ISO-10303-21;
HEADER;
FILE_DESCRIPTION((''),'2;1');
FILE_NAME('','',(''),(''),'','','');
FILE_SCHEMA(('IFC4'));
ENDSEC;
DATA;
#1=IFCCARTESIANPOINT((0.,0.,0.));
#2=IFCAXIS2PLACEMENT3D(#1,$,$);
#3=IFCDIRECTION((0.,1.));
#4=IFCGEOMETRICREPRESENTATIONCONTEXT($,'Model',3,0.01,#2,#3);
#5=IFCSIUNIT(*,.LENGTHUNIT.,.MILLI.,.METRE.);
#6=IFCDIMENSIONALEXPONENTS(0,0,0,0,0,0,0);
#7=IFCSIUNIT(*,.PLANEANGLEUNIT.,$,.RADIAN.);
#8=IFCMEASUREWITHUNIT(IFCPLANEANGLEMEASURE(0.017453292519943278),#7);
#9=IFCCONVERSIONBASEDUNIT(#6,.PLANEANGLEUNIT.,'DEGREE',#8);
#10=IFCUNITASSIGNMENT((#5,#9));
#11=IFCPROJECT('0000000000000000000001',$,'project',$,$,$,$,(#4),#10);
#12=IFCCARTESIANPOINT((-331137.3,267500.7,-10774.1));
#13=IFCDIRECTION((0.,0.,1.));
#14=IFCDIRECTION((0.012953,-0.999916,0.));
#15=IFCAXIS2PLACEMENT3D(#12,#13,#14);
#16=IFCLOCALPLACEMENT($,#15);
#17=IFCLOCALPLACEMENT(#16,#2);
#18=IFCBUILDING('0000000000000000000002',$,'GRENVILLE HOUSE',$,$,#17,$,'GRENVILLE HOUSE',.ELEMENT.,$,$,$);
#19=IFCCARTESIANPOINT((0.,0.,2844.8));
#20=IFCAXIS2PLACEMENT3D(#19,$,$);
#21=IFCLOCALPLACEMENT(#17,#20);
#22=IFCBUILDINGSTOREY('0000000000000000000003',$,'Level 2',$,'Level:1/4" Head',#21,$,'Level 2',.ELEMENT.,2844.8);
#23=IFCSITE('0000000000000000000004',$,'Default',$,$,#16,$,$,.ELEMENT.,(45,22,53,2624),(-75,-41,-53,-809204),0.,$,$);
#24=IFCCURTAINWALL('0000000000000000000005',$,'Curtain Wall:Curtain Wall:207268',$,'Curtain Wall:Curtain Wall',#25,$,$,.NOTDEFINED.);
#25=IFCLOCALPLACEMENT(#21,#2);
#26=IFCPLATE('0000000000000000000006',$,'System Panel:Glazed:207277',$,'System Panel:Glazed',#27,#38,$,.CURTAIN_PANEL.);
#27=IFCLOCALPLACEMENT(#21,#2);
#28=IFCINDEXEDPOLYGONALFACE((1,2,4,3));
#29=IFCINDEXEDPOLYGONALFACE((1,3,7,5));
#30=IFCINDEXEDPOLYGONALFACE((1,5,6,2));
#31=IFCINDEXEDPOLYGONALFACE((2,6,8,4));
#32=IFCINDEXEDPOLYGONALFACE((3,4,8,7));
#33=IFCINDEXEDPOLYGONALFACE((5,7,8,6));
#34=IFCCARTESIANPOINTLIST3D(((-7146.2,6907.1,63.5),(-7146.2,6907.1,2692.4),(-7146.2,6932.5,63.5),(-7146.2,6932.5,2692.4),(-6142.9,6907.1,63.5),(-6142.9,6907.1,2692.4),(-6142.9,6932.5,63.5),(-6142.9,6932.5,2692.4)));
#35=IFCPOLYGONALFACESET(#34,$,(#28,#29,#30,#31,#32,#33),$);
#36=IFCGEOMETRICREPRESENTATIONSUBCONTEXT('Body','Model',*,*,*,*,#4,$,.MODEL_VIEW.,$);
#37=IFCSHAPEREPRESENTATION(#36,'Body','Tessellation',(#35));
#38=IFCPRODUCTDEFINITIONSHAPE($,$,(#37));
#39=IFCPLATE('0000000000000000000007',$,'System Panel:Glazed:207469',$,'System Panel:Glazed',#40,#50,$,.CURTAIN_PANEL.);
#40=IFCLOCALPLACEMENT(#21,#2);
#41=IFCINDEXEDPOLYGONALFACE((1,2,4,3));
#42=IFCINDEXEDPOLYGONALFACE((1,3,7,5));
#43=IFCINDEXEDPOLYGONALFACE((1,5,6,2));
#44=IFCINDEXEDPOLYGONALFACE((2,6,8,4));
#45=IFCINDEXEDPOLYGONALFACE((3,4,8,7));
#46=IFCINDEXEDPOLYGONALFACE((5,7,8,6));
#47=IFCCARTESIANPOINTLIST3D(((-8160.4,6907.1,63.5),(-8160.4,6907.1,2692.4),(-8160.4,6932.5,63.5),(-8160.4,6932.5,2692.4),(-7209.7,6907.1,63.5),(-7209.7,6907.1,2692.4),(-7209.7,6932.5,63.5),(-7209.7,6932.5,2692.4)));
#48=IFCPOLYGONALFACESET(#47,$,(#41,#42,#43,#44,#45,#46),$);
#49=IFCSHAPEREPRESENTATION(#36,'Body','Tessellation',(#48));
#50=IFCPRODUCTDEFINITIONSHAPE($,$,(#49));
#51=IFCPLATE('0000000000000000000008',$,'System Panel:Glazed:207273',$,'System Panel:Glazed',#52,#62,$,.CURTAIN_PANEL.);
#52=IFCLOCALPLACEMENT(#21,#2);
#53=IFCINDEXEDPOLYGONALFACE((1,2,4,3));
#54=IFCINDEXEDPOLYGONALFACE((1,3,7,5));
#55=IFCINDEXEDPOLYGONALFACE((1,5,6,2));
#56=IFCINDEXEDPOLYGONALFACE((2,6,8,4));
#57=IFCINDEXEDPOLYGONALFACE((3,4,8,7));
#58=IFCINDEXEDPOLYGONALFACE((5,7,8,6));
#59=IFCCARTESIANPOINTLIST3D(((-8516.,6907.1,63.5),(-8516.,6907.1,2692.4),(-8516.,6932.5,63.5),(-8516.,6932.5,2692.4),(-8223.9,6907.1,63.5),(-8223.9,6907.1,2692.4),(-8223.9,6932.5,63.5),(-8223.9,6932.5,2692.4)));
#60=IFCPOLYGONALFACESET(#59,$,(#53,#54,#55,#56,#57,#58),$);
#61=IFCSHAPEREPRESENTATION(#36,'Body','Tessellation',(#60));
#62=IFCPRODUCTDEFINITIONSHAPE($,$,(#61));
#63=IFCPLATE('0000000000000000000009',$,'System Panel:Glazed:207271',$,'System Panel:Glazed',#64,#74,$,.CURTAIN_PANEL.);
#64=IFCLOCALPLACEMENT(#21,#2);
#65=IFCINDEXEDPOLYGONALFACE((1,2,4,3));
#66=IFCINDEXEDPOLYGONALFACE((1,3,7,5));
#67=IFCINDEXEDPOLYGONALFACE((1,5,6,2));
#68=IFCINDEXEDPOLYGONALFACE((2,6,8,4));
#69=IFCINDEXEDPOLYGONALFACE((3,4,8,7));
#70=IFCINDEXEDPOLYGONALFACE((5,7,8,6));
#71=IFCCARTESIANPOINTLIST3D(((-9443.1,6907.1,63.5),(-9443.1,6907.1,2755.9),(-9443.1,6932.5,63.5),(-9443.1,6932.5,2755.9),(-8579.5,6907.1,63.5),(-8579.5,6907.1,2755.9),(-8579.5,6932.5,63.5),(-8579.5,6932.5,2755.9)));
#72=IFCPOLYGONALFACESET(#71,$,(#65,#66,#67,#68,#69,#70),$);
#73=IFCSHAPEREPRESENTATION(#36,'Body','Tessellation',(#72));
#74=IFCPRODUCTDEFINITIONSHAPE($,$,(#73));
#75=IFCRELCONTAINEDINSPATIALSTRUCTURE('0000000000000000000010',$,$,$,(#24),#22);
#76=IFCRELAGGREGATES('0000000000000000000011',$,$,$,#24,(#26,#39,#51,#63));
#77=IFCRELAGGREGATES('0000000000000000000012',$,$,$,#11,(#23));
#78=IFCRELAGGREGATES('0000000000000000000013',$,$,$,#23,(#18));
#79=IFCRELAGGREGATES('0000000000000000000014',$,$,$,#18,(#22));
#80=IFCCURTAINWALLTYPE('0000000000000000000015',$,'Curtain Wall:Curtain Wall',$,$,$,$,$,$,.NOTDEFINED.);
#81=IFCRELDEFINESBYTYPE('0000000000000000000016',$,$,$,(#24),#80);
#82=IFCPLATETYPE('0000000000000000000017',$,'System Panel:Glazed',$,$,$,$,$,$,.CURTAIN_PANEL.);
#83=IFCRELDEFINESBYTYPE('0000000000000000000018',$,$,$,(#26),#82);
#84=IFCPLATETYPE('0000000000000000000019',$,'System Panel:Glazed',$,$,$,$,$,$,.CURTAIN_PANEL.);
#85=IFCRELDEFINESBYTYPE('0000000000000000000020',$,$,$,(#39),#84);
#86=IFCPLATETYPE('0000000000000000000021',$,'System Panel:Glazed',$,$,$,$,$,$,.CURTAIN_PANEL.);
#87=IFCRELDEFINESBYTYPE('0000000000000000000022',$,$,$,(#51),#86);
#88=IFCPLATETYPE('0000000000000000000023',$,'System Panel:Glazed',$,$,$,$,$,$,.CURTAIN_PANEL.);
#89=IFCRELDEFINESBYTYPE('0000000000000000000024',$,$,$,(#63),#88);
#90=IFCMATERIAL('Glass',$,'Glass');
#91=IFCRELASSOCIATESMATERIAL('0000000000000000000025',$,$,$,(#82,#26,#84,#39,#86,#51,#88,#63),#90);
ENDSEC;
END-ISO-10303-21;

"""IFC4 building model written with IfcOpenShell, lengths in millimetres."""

from ifc_helpers import new_model, entity, si_unit, converted_unit, direction, frame, origin, place, context, subcontext, project, spatial, indexed_curve, outline, extrude, source, transform, mapped, material, type_object, type_shapes, element, aggregate, save


model = new_model("IFC4")

# Units and contexts
model_context = context("Model", 3, precision=0.01, world=origin(), true_north=direction((0.0, 1.0)))
body_context = subcontext(model_context, "Body", "Model", "MODEL_VIEW")
ifc_project = project(units=[si_unit("LENGTHUNIT", "METRE", prefix="MILLI"), converted_unit("PLANEANGLEUNIT", "DEGREE", entity("IfcPlaneAngleMeasure", 0.017453292519943278), si_unit("PLANEANGLEUNIT", "RADIAN"), dimensions=[0, 0, 0, 0, 0, 0, 0])], contexts=[model_context])

# Site, building, storey
site_placement = place(None, frame((-331137.3, 267500.7, -10774.1), z_axis=(0.0, 0.0, 1.0), x_axis=(0.012953, -0.999916, 0.0)))
site = spatial("IfcSite", under=ifc_project, at=site_placement, Name="Default", CompositionType="ELEMENT", RefLatitude=(45, 22, 53, 2624), RefLongitude=(-75, -41, -53, -809204), RefElevation=0.0)
building_placement = place(site_placement, origin())
building = spatial("IfcBuilding", under=site, at=building_placement, Name="GRENVILLE HOUSE", LongName="GRENVILLE HOUSE", CompositionType="ELEMENT")
storey_placement = place(building_placement, frame((0.0, 0.0, 2844.8)))
storey = spatial("IfcBuildingStorey", under=building, at=storey_placement, Name="Level 2", ObjectType="Level:1/4\" Head", LongName="Level 2", CompositionType="ELEMENT", Elevation=2844.8)

# Shared definitions
curtain_wall_type = type_object("IfcCurtainWallType", Name="Curtain Wall:Curtain Wall", PredefinedType="NOTDEFINED")

# Curtain wall
curtain_wall_1_placement = place(storey_placement, frame((0.0, 0.0, -2844.8)))
curtain_wall_1 = element("IfcCurtainWall", 1, at=curtain_wall_1_placement, inside=storey, type_object=curtain_wall_type, Name="Curtain Wall:Curtain Wall:207268", ObjectType="Curtain Wall:Curtain Wall", PredefinedType="NOTDEFINED")

# Plates
ifc_material_1 = material(Name="Glass", Category="Glass")
plate_type_1 = type_object("IfcPlateType", Name="System Panel:Glazed", PredefinedType="CURTAIN_PANEL", material=ifc_material_1)
shared_shape_1 = source(origin(), body_context, "Body", "SweptSolid", [
    extrude(outline(indexed_curve([(-12.7, -501.6), (12.7, -501.6), (12.7, 501.6), (-12.7, 501.6), (-12.7, -501.6)], self_intersect=False)), frame((501.6, 12.7, 0.0), z_axis=(0.0, 0.0, 1.0), x_axis=(0.0, 1.0, 0.0)), (0.0, 0.0, 1.0), 2628.9),
])
type_shapes(plate_type_1, [shared_shape_1])
plate_1_placement = place(curtain_wall_1_placement, frame((-6142.9, 6932.5, 2908.3), z_axis=(0.0, 0.0, 1.0), x_axis=(-1.0, 0.0, 0.0)))
plate_1 = element("IfcPlate", 2, at=plate_1_placement, type_object=plate_type_1, material=ifc_material_1, Name="System Panel:Glazed:207277", ObjectType="System Panel:Glazed", PredefinedType="CURTAIN_PANEL", context=body_context, shape_type="MappedRepresentation", body=[
    mapped(shared_shape_1, transform((0.0, 0.0, 0.0), scale=1.0)),
])
plate_type_2 = type_object("IfcPlateType", Name="System Panel:Glazed", PredefinedType="CURTAIN_PANEL", material=ifc_material_1)
shared_shape_2 = source(origin(), body_context, "Body", "SweptSolid", [
    extrude(outline(indexed_curve([(-12.7, -475.3), (12.7, -475.3), (12.7, 475.3), (-12.7, 475.3), (-12.7, -475.3)], self_intersect=False)), frame((475.3, 12.7, 0.0), z_axis=(0.0, 0.0, 1.0), x_axis=(0.0, 1.0, 0.0)), (0.0, 0.0, 1.0), 2628.9),
])
type_shapes(plate_type_2, [shared_shape_2])
plate_2_placement = place(curtain_wall_1_placement, frame((-7209.7, 6932.5, 2908.3), z_axis=(0.0, 0.0, 1.0), x_axis=(-1.0, 0.0, 0.0)))
plate_2 = element("IfcPlate", 3, at=plate_2_placement, type_object=plate_type_2, material=ifc_material_1, Name="System Panel:Glazed:207469", ObjectType="System Panel:Glazed", PredefinedType="CURTAIN_PANEL", context=body_context, shape_type="MappedRepresentation", body=[
    mapped(shared_shape_2, transform((0.0, 0.0, 0.0), scale=1.0)),
])
plate_type_3 = type_object("IfcPlateType", Name="System Panel:Glazed", PredefinedType="CURTAIN_PANEL", material=ifc_material_1)
shared_shape_3 = source(origin(), body_context, "Body", "SweptSolid", [
    extrude(outline(indexed_curve([(-12.7, -146.1), (12.7, -146.1), (12.7, 146.1), (-12.7, 146.1), (-12.7, -146.1)], self_intersect=False)), frame((146.1, 12.7, 0.0), z_axis=(0.0, 0.0, 1.0), x_axis=(0.0, 1.0, 0.0)), (0.0, 0.0, 1.0), 2628.9),
])
type_shapes(plate_type_3, [shared_shape_3])
plate_3_placement = place(curtain_wall_1_placement, frame((-8223.9, 6932.5, 2908.3), z_axis=(0.0, 0.0, 1.0), x_axis=(-1.0, 0.0, 0.0)))
plate_3 = element("IfcPlate", 4, at=plate_3_placement, type_object=plate_type_3, material=ifc_material_1, Name="System Panel:Glazed:207273", ObjectType="System Panel:Glazed", PredefinedType="CURTAIN_PANEL", context=body_context, shape_type="MappedRepresentation", body=[
    mapped(shared_shape_3, transform((0.0, 0.0, 0.0), scale=1.0)),
])
plate_type_4 = type_object("IfcPlateType", Name="System Panel:Glazed", PredefinedType="CURTAIN_PANEL", material=ifc_material_1)
shared_shape_4 = source(origin(), body_context, "Body", "SweptSolid", [
    extrude(outline(indexed_curve([(-12.7, -431.8), (12.7, -431.8), (12.7, 431.8), (-12.7, 431.8), (-12.7, -431.8)], self_intersect=False)), frame((431.8, 12.7, 0.0), z_axis=(0.0, 0.0, 1.0), x_axis=(0.0, 1.0, 0.0)), (0.0, 0.0, 1.0), 2692.4),
])
type_shapes(plate_type_4, [shared_shape_4])
plate_4_placement = place(curtain_wall_1_placement, frame((-8579.5, 6932.5, 2908.3), z_axis=(0.0, 0.0, 1.0), x_axis=(-1.0, 0.0, 0.0)))
plate_4 = element("IfcPlate", 5, at=plate_4_placement, type_object=plate_type_4, material=ifc_material_1, Name="System Panel:Glazed:207271", ObjectType="System Panel:Glazed", PredefinedType="CURTAIN_PANEL", context=body_context, shape_type="MappedRepresentation", body=[
    mapped(shared_shape_4, transform((0.0, 0.0, 0.0), scale=1.0)),
])
aggregate(curtain_wall_1, [plate_1, plate_2, plate_3, plate_4])

save(model, "model.ifc")
